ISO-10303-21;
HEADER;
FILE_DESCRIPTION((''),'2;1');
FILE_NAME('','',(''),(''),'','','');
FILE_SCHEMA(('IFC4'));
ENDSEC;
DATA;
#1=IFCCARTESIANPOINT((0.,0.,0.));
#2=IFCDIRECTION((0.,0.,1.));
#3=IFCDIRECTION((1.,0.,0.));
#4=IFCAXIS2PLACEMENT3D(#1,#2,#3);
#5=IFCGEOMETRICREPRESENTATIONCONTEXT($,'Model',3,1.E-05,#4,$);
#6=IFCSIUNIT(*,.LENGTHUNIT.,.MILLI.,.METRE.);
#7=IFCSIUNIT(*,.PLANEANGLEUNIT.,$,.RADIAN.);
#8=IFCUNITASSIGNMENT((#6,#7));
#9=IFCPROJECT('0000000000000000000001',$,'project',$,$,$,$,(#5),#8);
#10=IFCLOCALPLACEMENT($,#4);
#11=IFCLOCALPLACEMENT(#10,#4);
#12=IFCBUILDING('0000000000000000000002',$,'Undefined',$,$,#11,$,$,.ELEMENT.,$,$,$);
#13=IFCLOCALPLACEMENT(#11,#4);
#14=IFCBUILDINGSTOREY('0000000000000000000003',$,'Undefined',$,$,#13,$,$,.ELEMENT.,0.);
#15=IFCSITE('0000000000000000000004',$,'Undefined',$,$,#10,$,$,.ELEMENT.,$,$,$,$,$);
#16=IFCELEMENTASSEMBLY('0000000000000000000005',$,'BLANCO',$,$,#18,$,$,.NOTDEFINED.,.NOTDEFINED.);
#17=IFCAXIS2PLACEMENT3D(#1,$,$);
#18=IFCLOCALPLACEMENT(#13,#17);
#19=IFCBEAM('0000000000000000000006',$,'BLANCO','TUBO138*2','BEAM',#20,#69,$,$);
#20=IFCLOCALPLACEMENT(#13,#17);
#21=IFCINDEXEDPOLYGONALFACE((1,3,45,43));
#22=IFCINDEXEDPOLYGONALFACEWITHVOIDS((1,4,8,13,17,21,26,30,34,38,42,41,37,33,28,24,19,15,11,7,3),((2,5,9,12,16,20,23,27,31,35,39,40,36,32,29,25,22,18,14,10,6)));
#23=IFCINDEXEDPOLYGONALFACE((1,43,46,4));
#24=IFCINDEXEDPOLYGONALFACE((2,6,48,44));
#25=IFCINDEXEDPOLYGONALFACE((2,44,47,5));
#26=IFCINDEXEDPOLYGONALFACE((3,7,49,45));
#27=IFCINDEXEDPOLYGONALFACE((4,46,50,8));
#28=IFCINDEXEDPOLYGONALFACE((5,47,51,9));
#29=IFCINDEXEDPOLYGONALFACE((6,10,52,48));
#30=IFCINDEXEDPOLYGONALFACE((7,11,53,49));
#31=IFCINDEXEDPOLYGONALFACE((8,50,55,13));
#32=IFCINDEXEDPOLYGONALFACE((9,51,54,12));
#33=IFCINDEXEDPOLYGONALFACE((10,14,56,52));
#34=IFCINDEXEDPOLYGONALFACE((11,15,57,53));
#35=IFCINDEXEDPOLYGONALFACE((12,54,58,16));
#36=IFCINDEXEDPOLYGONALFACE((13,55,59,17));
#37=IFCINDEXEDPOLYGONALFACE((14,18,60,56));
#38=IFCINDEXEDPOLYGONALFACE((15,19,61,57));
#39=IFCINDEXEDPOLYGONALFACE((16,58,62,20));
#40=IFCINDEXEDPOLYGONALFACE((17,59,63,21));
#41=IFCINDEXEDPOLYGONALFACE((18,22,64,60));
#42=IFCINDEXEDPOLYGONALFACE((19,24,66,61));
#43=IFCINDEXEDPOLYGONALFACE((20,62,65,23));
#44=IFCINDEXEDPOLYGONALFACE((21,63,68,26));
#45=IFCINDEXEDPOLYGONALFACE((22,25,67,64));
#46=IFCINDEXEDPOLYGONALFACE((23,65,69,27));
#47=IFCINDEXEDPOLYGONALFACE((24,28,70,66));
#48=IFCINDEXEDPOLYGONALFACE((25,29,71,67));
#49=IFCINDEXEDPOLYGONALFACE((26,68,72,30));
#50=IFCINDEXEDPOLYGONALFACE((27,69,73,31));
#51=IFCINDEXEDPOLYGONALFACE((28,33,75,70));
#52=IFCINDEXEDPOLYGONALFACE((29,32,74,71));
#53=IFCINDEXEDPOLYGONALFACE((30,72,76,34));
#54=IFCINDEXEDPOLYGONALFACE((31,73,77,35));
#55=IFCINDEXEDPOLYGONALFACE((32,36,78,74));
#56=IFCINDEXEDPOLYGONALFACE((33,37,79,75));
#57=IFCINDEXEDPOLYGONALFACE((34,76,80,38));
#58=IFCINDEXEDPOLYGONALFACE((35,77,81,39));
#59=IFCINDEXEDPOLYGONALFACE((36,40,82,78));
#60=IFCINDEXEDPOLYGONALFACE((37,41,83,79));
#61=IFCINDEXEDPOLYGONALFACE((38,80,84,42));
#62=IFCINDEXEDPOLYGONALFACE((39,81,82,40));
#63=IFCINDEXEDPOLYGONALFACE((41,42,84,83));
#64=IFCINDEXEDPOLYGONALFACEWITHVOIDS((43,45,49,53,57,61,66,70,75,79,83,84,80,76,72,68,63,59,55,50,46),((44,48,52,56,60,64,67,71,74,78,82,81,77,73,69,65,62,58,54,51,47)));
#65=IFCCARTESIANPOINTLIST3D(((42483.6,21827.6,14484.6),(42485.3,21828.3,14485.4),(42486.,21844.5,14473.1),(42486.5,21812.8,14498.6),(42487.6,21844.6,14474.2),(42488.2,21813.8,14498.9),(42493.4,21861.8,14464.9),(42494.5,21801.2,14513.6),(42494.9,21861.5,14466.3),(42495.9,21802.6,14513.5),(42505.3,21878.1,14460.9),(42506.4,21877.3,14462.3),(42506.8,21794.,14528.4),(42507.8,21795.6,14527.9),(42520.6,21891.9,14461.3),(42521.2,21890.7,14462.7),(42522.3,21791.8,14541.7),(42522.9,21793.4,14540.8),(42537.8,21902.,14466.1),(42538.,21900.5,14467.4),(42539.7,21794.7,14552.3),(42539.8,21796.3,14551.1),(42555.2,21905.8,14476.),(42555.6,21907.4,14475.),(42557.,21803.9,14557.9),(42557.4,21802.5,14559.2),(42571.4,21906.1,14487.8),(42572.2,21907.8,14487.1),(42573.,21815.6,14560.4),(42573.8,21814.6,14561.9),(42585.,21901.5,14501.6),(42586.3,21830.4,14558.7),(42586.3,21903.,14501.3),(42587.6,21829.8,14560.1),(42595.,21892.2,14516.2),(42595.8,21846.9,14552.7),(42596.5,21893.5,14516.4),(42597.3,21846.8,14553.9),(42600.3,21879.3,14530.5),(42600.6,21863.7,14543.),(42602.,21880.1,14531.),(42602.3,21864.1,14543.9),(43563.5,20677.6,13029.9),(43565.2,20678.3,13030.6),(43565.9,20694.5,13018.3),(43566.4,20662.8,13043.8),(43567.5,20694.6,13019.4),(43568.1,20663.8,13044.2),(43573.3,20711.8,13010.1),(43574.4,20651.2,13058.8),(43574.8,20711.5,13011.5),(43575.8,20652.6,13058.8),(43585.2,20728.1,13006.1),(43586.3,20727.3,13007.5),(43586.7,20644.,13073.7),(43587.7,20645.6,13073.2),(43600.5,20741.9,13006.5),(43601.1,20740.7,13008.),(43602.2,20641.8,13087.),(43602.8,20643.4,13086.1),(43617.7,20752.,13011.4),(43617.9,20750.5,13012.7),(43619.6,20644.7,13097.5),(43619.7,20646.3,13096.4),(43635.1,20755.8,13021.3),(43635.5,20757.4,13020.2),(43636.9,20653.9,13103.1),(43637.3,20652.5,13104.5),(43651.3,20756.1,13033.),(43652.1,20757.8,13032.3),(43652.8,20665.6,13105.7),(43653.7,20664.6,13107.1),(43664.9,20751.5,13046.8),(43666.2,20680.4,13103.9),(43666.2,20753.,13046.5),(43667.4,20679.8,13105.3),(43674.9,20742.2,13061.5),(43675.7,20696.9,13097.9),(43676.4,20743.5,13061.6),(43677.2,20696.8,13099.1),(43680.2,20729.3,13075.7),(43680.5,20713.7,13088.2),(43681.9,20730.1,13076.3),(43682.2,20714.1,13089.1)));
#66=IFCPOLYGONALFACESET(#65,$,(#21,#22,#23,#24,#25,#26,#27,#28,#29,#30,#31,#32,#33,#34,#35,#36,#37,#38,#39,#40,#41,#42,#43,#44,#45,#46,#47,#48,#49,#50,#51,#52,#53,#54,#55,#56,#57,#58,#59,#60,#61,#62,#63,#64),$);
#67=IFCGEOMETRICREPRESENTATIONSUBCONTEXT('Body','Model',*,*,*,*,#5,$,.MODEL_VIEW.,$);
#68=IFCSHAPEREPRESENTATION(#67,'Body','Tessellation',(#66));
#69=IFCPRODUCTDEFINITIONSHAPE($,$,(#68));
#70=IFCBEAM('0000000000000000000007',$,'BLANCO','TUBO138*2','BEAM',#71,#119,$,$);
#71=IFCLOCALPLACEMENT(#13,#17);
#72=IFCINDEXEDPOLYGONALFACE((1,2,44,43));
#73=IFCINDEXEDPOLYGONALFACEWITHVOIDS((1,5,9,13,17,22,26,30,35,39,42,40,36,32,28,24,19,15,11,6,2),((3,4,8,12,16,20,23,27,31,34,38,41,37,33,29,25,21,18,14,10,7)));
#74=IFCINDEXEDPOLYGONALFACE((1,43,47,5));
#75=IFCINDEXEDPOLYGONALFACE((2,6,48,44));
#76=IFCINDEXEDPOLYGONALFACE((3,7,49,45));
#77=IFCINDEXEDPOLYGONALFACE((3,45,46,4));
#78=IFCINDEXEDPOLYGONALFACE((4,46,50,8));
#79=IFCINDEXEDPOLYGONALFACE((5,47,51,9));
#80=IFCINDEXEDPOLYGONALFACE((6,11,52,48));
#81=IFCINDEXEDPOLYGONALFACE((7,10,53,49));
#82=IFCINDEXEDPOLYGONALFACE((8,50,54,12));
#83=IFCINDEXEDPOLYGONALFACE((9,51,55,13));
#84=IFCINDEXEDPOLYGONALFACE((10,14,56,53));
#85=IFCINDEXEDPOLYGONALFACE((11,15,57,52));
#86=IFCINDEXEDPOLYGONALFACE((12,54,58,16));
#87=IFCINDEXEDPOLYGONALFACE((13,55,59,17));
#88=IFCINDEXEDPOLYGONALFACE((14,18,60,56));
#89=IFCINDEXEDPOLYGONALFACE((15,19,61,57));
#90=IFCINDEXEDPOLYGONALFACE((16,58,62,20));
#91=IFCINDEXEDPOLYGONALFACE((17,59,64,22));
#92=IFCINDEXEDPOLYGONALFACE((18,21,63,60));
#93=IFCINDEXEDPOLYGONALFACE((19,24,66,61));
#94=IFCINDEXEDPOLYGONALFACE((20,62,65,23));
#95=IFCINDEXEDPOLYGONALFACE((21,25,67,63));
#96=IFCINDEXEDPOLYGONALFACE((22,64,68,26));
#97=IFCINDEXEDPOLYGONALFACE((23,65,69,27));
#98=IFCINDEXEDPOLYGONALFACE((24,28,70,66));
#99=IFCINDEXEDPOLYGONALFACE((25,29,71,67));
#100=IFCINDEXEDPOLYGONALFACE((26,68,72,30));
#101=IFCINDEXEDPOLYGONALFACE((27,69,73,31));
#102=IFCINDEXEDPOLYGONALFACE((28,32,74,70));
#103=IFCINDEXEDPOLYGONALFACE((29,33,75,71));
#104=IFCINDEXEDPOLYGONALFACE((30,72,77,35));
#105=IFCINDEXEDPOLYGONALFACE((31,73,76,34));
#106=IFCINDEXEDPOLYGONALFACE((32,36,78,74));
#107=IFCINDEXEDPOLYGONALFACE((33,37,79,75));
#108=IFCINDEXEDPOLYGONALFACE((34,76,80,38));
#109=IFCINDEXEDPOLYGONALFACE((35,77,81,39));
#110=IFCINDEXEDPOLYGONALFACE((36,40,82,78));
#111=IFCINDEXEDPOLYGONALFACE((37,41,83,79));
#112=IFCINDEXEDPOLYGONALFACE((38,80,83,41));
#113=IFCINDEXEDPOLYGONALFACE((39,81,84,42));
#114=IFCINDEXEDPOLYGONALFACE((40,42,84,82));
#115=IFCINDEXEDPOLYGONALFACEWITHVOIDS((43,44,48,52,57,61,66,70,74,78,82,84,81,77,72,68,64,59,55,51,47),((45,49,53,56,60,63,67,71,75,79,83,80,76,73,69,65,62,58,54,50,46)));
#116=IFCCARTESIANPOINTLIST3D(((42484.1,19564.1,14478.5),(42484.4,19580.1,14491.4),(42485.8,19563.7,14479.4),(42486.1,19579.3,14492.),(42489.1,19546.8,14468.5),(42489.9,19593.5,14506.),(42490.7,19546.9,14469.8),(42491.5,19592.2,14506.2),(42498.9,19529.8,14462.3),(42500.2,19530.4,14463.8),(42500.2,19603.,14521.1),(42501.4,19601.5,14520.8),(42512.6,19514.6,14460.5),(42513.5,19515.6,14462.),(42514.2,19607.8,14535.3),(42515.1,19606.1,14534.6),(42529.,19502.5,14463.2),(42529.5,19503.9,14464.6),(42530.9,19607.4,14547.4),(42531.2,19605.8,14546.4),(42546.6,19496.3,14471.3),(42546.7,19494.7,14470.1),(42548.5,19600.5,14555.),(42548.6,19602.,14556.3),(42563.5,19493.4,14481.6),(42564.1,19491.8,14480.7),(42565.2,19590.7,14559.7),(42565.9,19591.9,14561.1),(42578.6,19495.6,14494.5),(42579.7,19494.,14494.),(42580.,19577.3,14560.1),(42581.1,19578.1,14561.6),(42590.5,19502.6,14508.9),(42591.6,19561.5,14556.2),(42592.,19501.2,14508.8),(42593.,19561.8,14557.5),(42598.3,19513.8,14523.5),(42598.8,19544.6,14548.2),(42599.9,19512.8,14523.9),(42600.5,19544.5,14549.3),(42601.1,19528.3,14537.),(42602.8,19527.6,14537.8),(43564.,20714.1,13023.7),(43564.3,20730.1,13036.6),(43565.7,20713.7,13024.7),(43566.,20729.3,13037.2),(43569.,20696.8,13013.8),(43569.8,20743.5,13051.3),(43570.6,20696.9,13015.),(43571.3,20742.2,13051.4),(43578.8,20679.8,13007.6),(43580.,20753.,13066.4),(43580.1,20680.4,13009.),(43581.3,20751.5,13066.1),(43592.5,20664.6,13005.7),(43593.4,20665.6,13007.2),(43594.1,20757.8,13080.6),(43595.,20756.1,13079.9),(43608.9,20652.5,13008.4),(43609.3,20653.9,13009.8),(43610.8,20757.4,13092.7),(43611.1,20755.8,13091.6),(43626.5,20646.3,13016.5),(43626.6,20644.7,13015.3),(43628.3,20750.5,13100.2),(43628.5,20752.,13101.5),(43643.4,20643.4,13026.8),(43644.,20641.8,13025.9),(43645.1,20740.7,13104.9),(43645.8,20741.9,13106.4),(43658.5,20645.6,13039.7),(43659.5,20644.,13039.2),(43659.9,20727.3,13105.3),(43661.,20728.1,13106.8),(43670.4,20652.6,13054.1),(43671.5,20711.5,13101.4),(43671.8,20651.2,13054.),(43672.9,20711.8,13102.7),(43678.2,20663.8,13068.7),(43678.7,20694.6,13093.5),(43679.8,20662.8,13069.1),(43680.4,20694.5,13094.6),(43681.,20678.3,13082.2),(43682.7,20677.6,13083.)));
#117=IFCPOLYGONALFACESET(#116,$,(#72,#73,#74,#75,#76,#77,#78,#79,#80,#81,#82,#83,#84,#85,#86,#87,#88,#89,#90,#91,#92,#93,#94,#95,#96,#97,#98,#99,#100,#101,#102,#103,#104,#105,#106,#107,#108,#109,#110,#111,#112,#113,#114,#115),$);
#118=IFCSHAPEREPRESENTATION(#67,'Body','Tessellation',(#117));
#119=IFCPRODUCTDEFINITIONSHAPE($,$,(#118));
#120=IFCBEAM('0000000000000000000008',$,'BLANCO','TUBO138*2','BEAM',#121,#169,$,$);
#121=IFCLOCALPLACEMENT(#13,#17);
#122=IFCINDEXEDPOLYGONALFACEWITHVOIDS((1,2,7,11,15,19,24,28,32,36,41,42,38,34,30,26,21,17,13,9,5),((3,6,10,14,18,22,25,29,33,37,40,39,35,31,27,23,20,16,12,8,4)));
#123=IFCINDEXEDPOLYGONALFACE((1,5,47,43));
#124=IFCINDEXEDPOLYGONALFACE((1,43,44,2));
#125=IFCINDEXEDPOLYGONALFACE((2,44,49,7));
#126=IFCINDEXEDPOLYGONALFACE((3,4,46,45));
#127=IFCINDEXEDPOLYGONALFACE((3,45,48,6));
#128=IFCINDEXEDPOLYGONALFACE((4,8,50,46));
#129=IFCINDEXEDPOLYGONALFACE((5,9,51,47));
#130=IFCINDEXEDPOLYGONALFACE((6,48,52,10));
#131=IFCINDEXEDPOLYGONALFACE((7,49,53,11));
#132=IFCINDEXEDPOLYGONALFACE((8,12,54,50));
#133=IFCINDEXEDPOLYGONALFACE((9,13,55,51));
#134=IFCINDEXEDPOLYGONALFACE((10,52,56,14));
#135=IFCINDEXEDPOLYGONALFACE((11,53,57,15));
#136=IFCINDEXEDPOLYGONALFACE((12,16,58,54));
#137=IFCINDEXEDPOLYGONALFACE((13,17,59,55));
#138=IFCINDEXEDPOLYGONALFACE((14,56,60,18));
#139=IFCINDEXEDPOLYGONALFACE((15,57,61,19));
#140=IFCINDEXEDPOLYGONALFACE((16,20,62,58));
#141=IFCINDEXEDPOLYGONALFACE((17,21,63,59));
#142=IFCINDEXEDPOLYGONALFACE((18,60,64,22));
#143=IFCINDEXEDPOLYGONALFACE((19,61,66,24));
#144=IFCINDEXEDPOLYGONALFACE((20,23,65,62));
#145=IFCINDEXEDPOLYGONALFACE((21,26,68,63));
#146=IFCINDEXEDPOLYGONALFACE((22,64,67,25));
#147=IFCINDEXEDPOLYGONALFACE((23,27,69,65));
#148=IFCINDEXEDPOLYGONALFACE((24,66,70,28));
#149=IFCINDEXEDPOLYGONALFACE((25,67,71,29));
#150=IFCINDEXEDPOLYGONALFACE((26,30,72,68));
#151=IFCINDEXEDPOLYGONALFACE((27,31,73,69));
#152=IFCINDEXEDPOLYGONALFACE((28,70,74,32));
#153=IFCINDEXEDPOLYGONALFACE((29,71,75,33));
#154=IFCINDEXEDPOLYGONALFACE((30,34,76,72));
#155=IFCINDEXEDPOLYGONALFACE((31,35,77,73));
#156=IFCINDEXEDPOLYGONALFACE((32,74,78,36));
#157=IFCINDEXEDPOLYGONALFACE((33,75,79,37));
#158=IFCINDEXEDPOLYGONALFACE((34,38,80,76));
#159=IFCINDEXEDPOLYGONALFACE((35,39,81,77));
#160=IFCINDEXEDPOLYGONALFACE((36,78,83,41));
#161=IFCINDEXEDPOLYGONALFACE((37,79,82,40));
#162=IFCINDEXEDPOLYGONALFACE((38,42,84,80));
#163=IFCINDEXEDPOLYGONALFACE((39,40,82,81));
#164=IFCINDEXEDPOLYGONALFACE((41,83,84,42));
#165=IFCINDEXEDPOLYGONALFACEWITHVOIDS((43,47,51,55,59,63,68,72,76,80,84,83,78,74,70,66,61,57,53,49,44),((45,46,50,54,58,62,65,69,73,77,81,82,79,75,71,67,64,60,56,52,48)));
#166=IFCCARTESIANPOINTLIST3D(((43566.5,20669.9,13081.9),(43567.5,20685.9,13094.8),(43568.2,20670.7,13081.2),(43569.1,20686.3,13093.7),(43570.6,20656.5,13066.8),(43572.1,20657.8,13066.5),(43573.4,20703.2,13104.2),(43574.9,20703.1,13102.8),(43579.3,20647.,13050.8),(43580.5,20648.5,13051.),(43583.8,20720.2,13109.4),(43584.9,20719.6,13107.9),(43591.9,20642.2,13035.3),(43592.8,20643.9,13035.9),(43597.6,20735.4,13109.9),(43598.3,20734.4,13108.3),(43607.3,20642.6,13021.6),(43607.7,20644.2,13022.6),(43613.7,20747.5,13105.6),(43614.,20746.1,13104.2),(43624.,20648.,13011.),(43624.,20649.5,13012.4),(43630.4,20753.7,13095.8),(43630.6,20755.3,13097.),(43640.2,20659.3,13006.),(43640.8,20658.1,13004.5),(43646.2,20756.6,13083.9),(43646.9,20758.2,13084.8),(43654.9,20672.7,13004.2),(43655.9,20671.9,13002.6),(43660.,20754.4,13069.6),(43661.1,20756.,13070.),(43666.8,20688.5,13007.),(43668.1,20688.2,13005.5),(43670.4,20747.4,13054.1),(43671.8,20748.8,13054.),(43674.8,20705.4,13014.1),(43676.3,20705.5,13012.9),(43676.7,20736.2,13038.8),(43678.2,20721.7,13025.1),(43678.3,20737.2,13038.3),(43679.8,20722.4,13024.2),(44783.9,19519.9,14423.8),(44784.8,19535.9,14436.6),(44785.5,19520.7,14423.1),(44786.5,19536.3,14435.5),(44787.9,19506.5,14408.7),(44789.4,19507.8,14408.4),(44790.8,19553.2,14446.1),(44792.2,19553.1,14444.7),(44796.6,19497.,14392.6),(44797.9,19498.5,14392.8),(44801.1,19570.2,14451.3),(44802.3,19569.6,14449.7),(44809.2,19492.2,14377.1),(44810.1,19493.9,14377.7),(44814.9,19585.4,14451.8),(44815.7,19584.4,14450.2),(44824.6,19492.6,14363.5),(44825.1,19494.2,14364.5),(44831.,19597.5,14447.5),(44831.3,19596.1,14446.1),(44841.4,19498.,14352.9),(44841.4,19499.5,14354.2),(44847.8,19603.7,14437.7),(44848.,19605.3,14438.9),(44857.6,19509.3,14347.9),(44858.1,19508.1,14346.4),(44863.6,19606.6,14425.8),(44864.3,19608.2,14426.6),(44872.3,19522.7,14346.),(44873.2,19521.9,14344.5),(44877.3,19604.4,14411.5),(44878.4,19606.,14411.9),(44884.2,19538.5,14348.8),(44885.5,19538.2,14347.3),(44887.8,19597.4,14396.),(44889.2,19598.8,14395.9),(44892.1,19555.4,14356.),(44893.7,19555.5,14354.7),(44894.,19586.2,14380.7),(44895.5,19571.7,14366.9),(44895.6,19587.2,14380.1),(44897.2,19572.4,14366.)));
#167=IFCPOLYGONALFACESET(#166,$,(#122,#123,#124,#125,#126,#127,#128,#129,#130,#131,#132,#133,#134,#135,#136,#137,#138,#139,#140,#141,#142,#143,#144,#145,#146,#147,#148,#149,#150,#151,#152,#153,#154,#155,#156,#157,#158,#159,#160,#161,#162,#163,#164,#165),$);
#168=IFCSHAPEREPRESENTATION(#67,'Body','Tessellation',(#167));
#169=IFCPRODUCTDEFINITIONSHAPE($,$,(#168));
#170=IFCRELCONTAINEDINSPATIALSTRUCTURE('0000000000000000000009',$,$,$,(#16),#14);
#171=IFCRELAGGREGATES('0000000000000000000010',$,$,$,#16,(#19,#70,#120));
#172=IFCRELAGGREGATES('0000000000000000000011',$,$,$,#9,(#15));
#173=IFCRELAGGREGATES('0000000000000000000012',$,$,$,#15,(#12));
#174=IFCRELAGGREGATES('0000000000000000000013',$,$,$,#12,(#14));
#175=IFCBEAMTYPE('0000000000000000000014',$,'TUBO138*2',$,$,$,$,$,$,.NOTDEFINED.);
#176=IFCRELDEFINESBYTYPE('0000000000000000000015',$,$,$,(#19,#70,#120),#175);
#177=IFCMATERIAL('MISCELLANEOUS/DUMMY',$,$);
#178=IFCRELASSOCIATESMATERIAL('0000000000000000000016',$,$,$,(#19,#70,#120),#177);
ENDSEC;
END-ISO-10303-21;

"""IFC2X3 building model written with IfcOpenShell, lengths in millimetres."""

from ifc_helpers import new_model, si_unit, frame, origin_with_axes, origin_2d_with_axis, place, context, subcontext, project, spatial, hollow_circle, extrude, material, type_object, element, aggregate, save


model = new_model("IFC2X3")

# Units and contexts
model_context = context("Model", 3, precision=1e-05, world=origin_with_axes())
body_context = subcontext(model_context, "Body", "Model", "MODEL_VIEW")
ifc_project = project(units=[si_unit("LENGTHUNIT", "METRE", prefix="MILLI"), si_unit("PLANEANGLEUNIT", "RADIAN")], contexts=[model_context])

# Site, building, storey
site_placement = place(None, origin_with_axes())
site = spatial("IfcSite", under=ifc_project, at=site_placement, Name="Undefined", CompositionType="ELEMENT")
building_placement = place(site_placement, origin_with_axes())
building = spatial("IfcBuilding", under=site, at=building_placement, Name="Undefined", CompositionType="ELEMENT")
storey_placement = place(building_placement, origin_with_axes())
storey = spatial("IfcBuildingStorey", under=building, at=storey_placement, Name="Undefined", CompositionType="ELEMENT", Elevation=0.0)

# Element assembly, beams
assembly_placement = place(storey_placement, origin_with_axes())
assembly = element("IfcElementAssembly", 1, at=assembly_placement, inside=storey, Name="BLANCO", AssemblyPlace="NOTDEFINED", PredefinedType="NOTDEFINED")
ifc_material = material(Name="MISCELLANEOUS/DUMMY")
beam_type = type_object("IfcBeamType", Name="TUBO138*2", PredefinedType="NOTDEFINED")
beam_1_placement = place(assembly_placement, frame((43623.1, 20700.0, 13056.4), z_axis=(-0.497966, 0.461316, -0.734314), x_axis=(-0.503224, 0.535899, 0.677922)))
beam_1 = element("IfcBeam", 2, at=beam_1_placement, type_object=beam_type, material=ifc_material, Name="BLANCO", Description="TUBO138*2", ObjectType="BEAM", context=body_context, shape_type="SweptSolid", body=[
    extrude(hollow_circle(Radius=69.0, WallThickness=2.0, at=origin_2d_with_axis()), frame((2145.9, 0.0, 0.0), z_axis=(-1.0, 0.0, 0.0), x_axis=(0.0, -1.0, 0.0)), (0.0, 0.0, 1.0), 2145.9),
])
beam_2_placement = place(assembly_placement, frame((43623.1, 20700.0, 13056.4), z_axis=(-0.497966, -0.461316, -0.734314), x_axis=(-0.503224, -0.535899, 0.677922)))
beam_2 = element("IfcBeam", 3, at=beam_2_placement, type_object=beam_type, material=ifc_material, Name="BLANCO", Description="TUBO138*2", ObjectType="BEAM", context=body_context, shape_type="SweptSolid", body=[
    extrude(hollow_circle(Radius=69.0, WallThickness=2.0, at=origin_2d_with_axis()), frame((2145.9, 0.0, 0.0), z_axis=(-1.0, 0.0, 0.0), x_axis=(0.0, -1.0, 0.0)), (0.0, 0.0, 1.0), 2145.9),
])
beam_3_placement = place(assembly_placement, frame((43623.1, 20700.0, 13056.4), z_axis=(0.423552, -0.461316, -0.77961), x_axis=(0.567282, -0.535899, 0.625303)))
beam_3 = element("IfcBeam", 4, at=beam_3_placement, type_object=beam_type, material=ifc_material, Name="BLANCO", Description="TUBO138*2", ObjectType="BEAM", context=body_context, shape_type="SweptSolid", body=[
    extrude(hollow_circle(Radius=69.0, WallThickness=2.0, at=origin_2d_with_axis()), frame((2145.9, 0.0, 0.0), z_axis=(-1.0, 0.0, 0.0), x_axis=(0.0, -1.0, 0.0)), (0.0, 0.0, 1.0), 2145.9),
])
aggregate(assembly, [beam_1, beam_2, beam_3])

save(model, "model.ifc")
